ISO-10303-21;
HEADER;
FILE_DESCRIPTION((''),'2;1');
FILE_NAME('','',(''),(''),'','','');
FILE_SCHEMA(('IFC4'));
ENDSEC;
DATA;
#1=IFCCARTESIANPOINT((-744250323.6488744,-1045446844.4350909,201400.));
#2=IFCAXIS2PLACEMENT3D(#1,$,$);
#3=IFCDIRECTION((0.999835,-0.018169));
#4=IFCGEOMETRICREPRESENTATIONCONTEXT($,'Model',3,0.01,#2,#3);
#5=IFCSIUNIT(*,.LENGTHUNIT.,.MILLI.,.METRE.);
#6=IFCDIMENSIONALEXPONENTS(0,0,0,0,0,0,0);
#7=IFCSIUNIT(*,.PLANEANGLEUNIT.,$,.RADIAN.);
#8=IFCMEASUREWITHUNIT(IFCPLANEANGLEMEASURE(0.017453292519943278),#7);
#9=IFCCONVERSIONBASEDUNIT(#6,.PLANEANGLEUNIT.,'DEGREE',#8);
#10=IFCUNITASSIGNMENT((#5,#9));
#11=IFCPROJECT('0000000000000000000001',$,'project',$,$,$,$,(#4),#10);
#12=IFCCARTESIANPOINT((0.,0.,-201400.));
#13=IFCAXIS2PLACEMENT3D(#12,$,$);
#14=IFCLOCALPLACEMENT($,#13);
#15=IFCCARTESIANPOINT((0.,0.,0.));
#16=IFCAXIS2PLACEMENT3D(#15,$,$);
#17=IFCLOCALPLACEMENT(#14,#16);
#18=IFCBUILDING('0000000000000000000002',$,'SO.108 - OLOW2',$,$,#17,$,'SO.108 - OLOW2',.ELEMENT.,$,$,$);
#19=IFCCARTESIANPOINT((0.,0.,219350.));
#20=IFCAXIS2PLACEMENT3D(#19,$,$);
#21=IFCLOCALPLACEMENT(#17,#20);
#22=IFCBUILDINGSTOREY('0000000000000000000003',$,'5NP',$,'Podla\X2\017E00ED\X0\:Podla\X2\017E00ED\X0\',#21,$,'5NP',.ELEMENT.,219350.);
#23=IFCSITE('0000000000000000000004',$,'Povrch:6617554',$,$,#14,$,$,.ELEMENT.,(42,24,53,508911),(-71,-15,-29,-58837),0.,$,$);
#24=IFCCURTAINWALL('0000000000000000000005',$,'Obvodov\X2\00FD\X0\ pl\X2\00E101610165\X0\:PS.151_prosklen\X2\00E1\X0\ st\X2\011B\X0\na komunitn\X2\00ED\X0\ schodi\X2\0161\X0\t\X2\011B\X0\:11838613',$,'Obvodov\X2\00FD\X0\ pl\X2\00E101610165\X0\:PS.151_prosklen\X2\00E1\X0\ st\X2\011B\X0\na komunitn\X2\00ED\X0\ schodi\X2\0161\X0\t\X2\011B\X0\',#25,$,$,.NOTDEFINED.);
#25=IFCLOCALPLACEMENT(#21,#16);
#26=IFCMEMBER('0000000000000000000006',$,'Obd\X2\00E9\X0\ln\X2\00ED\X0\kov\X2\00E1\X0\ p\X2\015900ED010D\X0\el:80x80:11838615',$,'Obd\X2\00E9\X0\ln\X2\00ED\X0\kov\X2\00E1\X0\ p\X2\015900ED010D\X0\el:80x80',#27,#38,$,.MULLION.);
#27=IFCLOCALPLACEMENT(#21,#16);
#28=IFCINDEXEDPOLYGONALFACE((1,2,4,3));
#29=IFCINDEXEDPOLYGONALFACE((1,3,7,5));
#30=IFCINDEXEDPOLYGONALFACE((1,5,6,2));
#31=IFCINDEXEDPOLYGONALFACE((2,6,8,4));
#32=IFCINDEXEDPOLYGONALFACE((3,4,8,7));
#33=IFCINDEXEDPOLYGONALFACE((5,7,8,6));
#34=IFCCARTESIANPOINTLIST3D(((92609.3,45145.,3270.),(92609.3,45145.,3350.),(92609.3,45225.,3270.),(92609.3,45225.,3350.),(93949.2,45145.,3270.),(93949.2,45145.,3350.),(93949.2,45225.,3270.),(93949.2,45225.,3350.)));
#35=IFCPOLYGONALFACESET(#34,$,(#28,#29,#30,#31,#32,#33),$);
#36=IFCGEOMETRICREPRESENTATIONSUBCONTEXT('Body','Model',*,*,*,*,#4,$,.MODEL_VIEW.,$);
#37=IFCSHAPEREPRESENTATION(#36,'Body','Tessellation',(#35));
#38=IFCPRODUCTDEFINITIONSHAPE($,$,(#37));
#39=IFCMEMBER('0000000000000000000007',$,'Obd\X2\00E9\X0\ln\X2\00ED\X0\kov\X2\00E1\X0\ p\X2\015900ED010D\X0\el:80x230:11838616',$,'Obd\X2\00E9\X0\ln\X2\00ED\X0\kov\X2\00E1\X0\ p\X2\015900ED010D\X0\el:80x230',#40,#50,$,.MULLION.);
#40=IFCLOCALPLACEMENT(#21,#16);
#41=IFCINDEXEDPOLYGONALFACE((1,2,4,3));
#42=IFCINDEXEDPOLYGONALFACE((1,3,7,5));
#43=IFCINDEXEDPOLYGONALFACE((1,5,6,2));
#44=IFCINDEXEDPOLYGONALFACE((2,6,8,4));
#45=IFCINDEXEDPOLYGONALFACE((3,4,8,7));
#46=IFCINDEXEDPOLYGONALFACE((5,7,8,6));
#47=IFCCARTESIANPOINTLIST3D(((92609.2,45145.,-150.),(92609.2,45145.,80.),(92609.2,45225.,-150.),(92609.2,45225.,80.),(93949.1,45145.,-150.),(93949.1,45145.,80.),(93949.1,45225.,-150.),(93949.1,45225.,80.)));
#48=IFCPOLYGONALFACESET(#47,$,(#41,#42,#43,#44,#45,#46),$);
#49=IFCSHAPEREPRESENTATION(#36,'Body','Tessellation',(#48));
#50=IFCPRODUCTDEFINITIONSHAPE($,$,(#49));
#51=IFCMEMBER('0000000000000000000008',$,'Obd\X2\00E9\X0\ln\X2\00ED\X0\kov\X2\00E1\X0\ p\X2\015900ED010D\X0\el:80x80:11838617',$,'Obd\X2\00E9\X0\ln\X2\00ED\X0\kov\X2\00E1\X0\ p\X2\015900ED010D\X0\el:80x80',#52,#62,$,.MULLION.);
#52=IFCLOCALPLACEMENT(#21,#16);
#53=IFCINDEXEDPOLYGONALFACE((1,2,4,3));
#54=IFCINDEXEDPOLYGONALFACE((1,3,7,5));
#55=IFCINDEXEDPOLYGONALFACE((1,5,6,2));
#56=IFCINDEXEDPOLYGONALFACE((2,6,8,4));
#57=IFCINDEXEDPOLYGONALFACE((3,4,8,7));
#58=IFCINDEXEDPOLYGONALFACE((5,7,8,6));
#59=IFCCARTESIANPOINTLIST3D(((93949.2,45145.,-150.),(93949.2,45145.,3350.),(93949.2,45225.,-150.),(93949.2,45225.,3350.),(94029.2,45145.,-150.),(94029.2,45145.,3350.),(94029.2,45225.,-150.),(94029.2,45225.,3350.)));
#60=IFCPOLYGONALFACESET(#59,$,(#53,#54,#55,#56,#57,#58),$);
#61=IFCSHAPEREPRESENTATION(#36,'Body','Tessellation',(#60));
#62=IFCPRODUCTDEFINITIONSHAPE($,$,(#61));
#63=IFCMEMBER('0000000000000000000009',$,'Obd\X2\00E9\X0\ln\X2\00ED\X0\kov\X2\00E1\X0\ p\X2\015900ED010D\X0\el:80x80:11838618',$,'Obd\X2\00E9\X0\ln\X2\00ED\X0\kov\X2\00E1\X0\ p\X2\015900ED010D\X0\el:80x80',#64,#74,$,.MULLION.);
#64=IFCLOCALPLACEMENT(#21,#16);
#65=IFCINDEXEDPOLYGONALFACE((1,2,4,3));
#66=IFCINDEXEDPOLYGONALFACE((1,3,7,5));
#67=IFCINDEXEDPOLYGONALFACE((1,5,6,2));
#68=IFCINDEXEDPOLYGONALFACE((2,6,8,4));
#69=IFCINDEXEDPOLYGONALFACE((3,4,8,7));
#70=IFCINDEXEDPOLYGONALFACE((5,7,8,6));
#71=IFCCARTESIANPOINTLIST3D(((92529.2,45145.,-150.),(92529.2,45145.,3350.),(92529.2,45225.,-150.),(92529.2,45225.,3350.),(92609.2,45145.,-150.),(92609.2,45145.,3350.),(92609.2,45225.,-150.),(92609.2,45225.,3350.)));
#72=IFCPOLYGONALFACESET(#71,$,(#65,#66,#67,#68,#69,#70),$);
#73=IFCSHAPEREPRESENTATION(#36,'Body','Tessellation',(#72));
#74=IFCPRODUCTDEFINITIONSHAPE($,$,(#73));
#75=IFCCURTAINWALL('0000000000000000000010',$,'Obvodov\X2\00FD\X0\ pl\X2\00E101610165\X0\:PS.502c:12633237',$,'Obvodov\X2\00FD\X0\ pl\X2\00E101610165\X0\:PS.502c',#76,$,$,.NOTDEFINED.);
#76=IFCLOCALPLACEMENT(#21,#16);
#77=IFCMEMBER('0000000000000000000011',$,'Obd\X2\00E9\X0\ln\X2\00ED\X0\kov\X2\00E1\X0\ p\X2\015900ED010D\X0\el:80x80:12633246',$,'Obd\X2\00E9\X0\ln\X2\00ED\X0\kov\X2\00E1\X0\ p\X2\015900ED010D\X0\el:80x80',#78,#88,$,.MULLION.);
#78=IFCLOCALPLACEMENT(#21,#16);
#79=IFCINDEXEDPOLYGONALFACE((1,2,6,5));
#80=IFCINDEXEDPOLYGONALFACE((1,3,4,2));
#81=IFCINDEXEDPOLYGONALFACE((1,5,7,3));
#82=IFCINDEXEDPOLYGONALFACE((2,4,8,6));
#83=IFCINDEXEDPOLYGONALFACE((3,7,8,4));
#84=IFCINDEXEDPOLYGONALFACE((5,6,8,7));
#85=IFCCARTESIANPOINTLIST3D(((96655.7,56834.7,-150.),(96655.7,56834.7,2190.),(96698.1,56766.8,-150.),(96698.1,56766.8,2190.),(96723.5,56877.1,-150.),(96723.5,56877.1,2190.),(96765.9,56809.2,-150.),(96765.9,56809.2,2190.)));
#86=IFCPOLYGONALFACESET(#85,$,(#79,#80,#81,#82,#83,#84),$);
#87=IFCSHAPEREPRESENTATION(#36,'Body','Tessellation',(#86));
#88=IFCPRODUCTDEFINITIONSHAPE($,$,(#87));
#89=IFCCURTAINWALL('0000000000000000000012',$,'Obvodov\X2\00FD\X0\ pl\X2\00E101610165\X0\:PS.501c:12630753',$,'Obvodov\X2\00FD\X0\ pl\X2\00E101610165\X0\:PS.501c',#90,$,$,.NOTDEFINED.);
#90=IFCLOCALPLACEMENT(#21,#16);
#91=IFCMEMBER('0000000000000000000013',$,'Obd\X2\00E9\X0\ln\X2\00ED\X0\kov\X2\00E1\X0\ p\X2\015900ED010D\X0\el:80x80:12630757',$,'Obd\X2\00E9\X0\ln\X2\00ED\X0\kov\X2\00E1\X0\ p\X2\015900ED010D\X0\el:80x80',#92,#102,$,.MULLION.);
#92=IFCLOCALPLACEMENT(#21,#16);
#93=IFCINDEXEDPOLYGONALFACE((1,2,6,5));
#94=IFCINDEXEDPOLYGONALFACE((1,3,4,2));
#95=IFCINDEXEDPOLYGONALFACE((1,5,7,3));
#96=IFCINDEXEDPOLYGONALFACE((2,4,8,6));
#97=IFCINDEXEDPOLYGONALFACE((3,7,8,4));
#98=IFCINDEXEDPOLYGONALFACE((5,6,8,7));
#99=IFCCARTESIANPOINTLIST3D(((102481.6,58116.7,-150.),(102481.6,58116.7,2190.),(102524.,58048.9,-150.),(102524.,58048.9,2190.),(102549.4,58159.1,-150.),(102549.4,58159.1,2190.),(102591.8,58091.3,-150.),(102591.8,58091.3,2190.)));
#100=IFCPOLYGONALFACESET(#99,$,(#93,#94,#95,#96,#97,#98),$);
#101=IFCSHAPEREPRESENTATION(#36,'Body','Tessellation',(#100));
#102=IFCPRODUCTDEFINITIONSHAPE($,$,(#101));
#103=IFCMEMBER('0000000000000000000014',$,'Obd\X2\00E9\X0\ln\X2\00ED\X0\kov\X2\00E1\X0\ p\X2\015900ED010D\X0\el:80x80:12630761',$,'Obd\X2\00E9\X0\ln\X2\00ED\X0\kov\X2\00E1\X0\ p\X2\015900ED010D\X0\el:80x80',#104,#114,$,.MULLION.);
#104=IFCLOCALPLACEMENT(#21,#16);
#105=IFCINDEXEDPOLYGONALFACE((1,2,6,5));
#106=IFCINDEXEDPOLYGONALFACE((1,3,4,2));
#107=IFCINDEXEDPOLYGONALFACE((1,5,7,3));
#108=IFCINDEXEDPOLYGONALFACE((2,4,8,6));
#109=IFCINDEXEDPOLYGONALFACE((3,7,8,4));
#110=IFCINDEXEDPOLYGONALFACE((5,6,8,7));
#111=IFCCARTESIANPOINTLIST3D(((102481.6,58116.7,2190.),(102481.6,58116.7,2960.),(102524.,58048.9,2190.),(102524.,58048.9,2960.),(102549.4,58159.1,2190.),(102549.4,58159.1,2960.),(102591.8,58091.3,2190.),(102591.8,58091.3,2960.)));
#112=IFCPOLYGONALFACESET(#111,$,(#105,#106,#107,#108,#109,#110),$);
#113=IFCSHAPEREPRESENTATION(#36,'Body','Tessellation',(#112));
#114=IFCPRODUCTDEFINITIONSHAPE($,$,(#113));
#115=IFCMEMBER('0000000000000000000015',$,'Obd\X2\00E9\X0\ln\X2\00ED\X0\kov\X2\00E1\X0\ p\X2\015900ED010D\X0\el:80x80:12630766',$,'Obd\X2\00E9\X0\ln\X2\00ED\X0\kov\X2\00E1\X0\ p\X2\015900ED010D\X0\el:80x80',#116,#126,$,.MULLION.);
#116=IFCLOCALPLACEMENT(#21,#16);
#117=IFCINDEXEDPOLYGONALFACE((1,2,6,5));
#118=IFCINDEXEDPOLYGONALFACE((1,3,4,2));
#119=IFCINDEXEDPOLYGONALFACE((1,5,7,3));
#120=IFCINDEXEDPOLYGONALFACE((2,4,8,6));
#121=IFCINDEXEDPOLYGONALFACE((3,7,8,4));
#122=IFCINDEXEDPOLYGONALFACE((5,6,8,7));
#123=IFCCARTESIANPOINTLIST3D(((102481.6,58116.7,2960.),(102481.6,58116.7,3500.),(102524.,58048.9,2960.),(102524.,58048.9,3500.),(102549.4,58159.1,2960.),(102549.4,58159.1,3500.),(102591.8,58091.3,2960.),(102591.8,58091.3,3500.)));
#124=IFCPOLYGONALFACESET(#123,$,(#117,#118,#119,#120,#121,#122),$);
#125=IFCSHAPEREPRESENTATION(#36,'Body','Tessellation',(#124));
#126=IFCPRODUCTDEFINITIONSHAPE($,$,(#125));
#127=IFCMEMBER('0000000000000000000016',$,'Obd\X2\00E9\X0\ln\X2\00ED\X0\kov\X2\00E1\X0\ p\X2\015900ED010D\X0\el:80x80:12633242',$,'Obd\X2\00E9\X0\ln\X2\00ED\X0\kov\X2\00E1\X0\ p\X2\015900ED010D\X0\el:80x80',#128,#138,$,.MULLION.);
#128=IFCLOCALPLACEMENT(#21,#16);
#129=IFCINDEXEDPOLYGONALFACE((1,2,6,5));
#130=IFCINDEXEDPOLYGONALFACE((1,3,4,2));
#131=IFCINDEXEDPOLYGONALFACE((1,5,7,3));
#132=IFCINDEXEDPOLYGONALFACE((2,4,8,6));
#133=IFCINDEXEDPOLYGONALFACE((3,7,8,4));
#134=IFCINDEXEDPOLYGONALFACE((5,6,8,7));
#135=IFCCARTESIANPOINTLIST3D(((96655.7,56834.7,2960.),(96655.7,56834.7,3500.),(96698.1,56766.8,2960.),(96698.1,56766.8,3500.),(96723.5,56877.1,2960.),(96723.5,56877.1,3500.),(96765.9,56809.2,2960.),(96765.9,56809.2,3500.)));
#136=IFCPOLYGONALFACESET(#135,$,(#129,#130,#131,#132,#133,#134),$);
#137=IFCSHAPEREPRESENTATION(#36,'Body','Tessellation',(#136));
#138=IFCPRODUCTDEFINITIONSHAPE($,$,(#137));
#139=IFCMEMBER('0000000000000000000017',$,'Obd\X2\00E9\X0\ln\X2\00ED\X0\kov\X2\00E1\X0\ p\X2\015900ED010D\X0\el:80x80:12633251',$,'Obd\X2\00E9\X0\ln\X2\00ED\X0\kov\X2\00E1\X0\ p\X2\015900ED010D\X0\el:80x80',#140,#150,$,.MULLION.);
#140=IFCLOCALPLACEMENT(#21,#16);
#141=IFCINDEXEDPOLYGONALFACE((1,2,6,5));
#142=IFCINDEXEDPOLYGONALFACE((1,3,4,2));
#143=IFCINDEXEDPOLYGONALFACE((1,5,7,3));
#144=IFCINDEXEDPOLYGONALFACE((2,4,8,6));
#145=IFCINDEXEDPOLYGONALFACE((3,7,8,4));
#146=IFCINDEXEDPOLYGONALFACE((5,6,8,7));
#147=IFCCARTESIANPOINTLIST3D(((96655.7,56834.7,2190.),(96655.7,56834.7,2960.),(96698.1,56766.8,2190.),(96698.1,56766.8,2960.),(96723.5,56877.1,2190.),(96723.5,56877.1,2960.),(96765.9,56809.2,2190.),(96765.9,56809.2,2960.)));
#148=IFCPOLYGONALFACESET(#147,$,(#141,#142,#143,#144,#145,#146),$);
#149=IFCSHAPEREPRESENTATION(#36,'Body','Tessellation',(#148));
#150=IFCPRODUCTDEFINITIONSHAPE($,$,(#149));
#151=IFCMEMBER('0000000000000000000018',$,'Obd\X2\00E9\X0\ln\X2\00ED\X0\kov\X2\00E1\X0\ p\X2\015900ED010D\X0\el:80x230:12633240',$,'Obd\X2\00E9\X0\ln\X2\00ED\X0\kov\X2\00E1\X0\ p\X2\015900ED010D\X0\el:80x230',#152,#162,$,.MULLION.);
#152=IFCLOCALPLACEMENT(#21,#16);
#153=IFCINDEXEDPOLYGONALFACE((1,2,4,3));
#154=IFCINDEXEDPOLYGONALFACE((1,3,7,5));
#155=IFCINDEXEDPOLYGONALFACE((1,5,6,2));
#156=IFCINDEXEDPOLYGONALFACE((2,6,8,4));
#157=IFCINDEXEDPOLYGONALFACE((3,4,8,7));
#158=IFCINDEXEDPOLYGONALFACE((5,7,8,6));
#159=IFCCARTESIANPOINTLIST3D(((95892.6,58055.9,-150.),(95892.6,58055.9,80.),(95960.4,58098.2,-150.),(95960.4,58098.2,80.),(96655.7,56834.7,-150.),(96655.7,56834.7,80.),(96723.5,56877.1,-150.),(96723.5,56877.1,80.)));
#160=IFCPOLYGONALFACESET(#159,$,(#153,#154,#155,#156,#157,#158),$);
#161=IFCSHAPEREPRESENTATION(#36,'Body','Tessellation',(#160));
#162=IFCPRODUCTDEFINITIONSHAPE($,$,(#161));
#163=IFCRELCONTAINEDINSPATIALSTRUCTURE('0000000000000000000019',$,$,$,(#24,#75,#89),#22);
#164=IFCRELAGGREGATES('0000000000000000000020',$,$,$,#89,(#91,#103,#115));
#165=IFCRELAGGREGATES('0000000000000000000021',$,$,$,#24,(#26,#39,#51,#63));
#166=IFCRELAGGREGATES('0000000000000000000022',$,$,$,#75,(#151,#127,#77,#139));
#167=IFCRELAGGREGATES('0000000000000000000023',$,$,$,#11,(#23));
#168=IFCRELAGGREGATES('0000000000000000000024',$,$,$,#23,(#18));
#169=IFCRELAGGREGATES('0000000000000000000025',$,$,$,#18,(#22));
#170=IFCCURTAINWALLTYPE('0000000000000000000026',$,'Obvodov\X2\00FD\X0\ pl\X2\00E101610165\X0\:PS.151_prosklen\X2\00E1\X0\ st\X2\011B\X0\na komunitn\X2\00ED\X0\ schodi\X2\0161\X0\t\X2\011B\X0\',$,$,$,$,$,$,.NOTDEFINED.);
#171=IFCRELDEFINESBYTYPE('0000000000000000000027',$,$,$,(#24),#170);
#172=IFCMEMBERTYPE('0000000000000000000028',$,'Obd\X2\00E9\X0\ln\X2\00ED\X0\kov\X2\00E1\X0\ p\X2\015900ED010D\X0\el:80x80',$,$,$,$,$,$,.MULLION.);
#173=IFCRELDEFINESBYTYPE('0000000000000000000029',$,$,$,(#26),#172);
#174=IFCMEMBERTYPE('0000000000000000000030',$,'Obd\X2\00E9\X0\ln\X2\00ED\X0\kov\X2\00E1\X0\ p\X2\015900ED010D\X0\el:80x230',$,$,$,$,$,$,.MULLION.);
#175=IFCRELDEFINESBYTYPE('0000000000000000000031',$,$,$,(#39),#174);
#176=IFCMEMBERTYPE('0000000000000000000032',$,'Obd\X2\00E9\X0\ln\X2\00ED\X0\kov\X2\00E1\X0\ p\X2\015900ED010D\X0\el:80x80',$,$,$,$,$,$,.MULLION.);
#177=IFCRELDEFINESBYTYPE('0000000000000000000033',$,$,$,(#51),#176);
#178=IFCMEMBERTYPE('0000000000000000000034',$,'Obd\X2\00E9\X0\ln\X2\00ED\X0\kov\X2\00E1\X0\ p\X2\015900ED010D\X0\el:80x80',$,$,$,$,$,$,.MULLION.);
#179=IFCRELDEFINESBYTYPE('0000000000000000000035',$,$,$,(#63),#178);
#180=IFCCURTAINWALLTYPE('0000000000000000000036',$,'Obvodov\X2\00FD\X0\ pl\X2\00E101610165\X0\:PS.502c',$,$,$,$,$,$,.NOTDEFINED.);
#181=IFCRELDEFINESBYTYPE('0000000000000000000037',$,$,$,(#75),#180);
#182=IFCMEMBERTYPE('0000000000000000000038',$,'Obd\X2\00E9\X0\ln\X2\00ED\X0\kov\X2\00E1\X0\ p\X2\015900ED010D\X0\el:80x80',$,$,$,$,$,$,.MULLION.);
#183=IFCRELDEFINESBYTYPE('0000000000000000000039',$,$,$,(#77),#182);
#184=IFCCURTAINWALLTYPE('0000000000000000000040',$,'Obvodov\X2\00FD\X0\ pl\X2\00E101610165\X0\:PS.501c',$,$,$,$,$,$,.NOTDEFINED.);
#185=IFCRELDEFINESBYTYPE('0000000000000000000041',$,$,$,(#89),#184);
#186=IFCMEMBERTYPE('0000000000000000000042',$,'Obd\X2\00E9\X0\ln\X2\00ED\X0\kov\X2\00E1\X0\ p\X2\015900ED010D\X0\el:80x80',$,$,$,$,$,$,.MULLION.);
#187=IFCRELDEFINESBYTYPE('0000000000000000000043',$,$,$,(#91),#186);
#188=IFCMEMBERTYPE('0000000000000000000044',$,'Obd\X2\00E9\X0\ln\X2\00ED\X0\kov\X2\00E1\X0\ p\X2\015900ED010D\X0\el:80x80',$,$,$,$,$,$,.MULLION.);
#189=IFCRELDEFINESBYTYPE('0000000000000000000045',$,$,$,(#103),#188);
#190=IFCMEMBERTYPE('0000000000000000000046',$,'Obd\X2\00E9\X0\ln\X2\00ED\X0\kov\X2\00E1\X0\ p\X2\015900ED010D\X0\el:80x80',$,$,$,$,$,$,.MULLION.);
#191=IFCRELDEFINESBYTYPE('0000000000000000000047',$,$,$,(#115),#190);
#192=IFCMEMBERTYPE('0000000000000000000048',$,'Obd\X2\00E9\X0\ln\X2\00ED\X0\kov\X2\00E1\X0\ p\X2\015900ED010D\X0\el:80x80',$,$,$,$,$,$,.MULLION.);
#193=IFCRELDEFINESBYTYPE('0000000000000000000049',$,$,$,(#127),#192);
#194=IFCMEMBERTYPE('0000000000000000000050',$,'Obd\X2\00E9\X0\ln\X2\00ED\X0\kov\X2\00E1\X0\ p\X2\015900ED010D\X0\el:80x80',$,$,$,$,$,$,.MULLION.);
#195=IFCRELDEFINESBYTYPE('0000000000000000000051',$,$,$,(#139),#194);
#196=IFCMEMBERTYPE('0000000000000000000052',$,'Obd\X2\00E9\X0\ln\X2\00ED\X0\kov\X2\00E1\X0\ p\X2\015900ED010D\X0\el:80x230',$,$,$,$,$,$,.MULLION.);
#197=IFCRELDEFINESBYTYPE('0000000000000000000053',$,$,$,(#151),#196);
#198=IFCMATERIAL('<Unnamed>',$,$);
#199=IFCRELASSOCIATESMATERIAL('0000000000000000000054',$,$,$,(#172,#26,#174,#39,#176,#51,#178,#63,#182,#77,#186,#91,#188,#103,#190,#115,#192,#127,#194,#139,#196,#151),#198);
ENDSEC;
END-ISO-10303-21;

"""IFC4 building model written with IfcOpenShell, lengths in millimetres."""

from ifc_helpers import new_model, entity, si_unit, converted_unit, direction, frame, origin, place, context, subcontext, project, spatial, indexed_curve, outline, extrude, source, transform, mapped, material, type_object, type_shapes, element, aggregate, save


model = new_model("IFC4")

# Units and contexts
model_context = context("Model", 3, precision=0.01, world=frame((-744250323.6488744, -1045446844.4350909, 201400.0)), true_north=direction((0.999835, -0.018169)))
body_context = subcontext(model_context, "Body", "Model", "MODEL_VIEW")
ifc_project = project(units=[si_unit("LENGTHUNIT", "METRE", prefix="MILLI"), converted_unit("PLANEANGLEUNIT", "DEGREE", entity("IfcPlaneAngleMeasure", 0.017453292519943278), si_unit("PLANEANGLEUNIT", "RADIAN"), dimensions=[0, 0, 0, 0, 0, 0, 0])], contexts=[model_context])

# Site, building, storey
site_placement = place(None, frame((0.0, 0.0, -201400.0)))
site = spatial("IfcSite", under=ifc_project, at=site_placement, Name="Povrch:6617554", CompositionType="ELEMENT", RefLatitude=(42, 24, 53, 508911), RefLongitude=(-71, -15, -29, -58837), RefElevation=0.0)
building_placement = place(site_placement, origin())
building = spatial("IfcBuilding", under=site, at=building_placement, Name="SO.108 - OLOW2", LongName="SO.108 - OLOW2", CompositionType="ELEMENT")
storey_placement = place(building_placement, frame((0.0, 0.0, 219350.0)))
storey = spatial("IfcBuildingStorey", under=building, at=storey_placement, Name="5NP", ObjectType="Podlaží:Podlaží", LongName="5NP", CompositionType="ELEMENT", Elevation=219350.0)

# Curtain wall, members
curtain_wall_type_1 = type_object("IfcCurtainWallType", Name="Obvodový plášť:PS.151_prosklená stěna komunitní schodiště", PredefinedType="NOTDEFINED")
curtain_wall_1_placement = place(storey_placement, frame((0.0, 0.0, -219350.0)))
curtain_wall_1 = element("IfcCurtainWall", 1, at=curtain_wall_1_placement, inside=storey, type_object=curtain_wall_type_1, Name="Obvodový plášť:PS.151_prosklená stěna komunitní schodiště:11838613", ObjectType="Obvodový plášť:PS.151_prosklená stěna komunitní schodiště", PredefinedType="NOTDEFINED")
ifc_material_1 = material(Name="<Unnamed>")
member_type_1 = type_object("IfcMemberType", Name="Obdélníková příčel:80x80", PredefinedType="MULLION", material=ifc_material_1)
shared_shape_1 = source(origin(), body_context, "Body", "SweptSolid", [
    extrude(outline(indexed_curve([(-40.0, -40.0), (40.0, -40.0), (40.0, 40.0), (-40.0, 40.0), (-40.0, -40.0)], self_intersect=False)), frame((-40.0, 0.0, -1339.9), z_axis=(0.0, 0.0, 1.0), x_axis=(-1.0, 0.0, 0.0)), (0.0, 0.0, 1.0), 1339.9),
])
type_shapes(member_type_1, [shared_shape_1])
member_1_placement = place(curtain_wall_1_placement, frame((93949.2, 45185.0, 222700.0), z_axis=(1.0, 0.0, 0.0), x_axis=(0.0, 0.0, 1.0)))
member_1 = element("IfcMember", 2, at=member_1_placement, type_object=member_type_1, material=ifc_material_1, Name="Obdélníková příčel:80x80:11838615", ObjectType="Obdélníková příčel:80x80", PredefinedType="MULLION", context=body_context, shape_type="MappedRepresentation", body=[
    mapped(shared_shape_1, transform((0.0, 0.0, 0.0), scale=1.0)),
])
member_type_2 = type_object("IfcMemberType", Name="Obdélníková příčel:80x230", PredefinedType="MULLION", material=ifc_material_1)
shared_shape_2 = source(origin(), body_context, "Body", "SweptSolid", [
    extrude(outline(indexed_curve([(-115.0, -40.0), (115.0, -40.0), (115.0, 40.0), (-115.0, 40.0), (-115.0, -40.0)], self_intersect=False)), frame((-115.0, 0.0, -1339.9), z_axis=(0.0, 0.0, 1.0), x_axis=(-1.0, 0.0, 0.0)), (0.0, 0.0, 1.0), 1339.9),
])
type_shapes(member_type_2, [shared_shape_2])
member_2_placement = place(curtain_wall_1_placement, frame((92609.2, 45185.0, 219200.0), z_axis=(-1.0, 0.0, 0.0), x_axis=(0.0, 0.0, -1.0)))
member_2 = element("IfcMember", 3, at=member_2_placement, type_object=member_type_2, material=ifc_material_1, Name="Obdélníková příčel:80x230:11838616", ObjectType="Obdélníková příčel:80x230", PredefinedType="MULLION", context=body_context, shape_type="MappedRepresentation", body=[
    mapped(shared_shape_2, transform((0.0, 0.0, 0.0), scale=1.0)),
])
member_type_3 = type_object("IfcMemberType", Name="Obdélníková příčel:80x80", PredefinedType="MULLION", material=ifc_material_1)
shared_shape_3 = source(origin(), body_context, "Body", "SweptSolid", [
    extrude(outline(indexed_curve([(-40.0, -40.0), (40.0, -40.0), (40.0, 40.0), (-40.0, 40.0), (-40.0, -40.0)], self_intersect=False)), frame((-40.0, 0.0, -3500.0), z_axis=(0.0, 0.0, 1.0), x_axis=(-1.0, 0.0, 0.0)), (0.0, 0.0, 1.0), 3500.0),
])
type_shapes(member_type_3, [shared_shape_3])
member_3_placement = place(curtain_wall_1_placement, frame((94029.2, 45185.0, 219200.0), z_axis=(0.0, 0.0, -1.0), x_axis=(1.0, 0.0, 0.0)))
member_3 = element("IfcMember", 4, at=member_3_placement, type_object=member_type_3, material=ifc_material_1, Name="Obdélníková příčel:80x80:11838617", ObjectType="Obdélníková příčel:80x80", PredefinedType="MULLION", context=body_context, shape_type="MappedRepresentation", body=[
    mapped(shared_shape_3, transform((0.0, 0.0, 0.0), scale=1.0)),
])
member_type_4 = type_object("IfcMemberType", Name="Obdélníková příčel:80x80", PredefinedType="MULLION", material=ifc_material_1)
shared_shape_4 = source(origin(), body_context, "Body", "SweptSolid", [
    extrude(outline(indexed_curve([(-40.0, -40.0), (40.0, -40.0), (40.0, 40.0), (-40.0, 40.0), (-40.0, -40.0)], self_intersect=False)), frame((-40.0, 0.0, -3500.0), z_axis=(0.0, 0.0, 1.0), x_axis=(-1.0, 0.0, 0.0)), (0.0, 0.0, 1.0), 3500.0),
])
type_shapes(member_type_4, [shared_shape_4])
member_4_placement = place(curtain_wall_1_placement, frame((92529.2, 45185.0, 222700.0), z_axis=(0.0, 0.0, 1.0), x_axis=(-1.0, 0.0, 0.0)))
member_4 = element("IfcMember", 5, at=member_4_placement, type_object=member_type_4, material=ifc_material_1, Name="Obdélníková příčel:80x80:11838618", ObjectType="Obdélníková příčel:80x80", PredefinedType="MULLION", context=body_context, shape_type="MappedRepresentation", body=[
    mapped(shared_shape_4, transform((0.0, 0.0, 0.0), scale=1.0)),
])

# Curtain wall, member
curtain_wall_type_2 = type_object("IfcCurtainWallType", Name="Obvodový plášť:PS.502c", PredefinedType="NOTDEFINED")
curtain_wall_2_placement = place(storey_placement, frame((0.0, 0.0, -219350.0)))
curtain_wall_2 = element("IfcCurtainWall", 6, at=curtain_wall_2_placement, inside=storey, type_object=curtain_wall_type_2, Name="Obvodový plášť:PS.502c:12633237", ObjectType="Obvodový plášť:PS.502c", PredefinedType="NOTDEFINED")
member_type_5 = type_object("IfcMemberType", Name="Obdélníková příčel:80x80", PredefinedType="MULLION", material=ifc_material_1)
shared_shape_5 = source(origin(), body_context, "Body", "SweptSolid", [
    extrude(outline(indexed_curve([(-40.0, -40.0), (40.0, -40.0), (40.0, 40.0), (-40.0, 40.0), (-40.0, -40.0)], self_intersect=False)), frame((-40.0, 0.0, -2340.0), z_axis=(0.0, 0.0, 1.0), x_axis=(-1.0, 0.0, 0.0)), (0.0, 0.0, 1.0), 2340.0),
])
type_shapes(member_type_5, [shared_shape_5])
member_5_placement = place(curtain_wall_2_placement, frame((96732.0, 56788.0, 221540.0), z_axis=(0.0, 0.0, 1.0), x_axis=(0.529919, -0.848048, 0.0)))
member_5 = element("IfcMember", 7, at=member_5_placement, type_object=member_type_5, material=ifc_material_1, Name="Obdélníková příčel:80x80:12633246", ObjectType="Obdélníková příčel:80x80", PredefinedType="MULLION", context=body_context, shape_type="MappedRepresentation", body=[
    mapped(shared_shape_5, transform((0.0, 0.0, 0.0), scale=1.0)),
])

# Curtain wall, members
curtain_wall_type_3 = type_object("IfcCurtainWallType", Name="Obvodový plášť:PS.501c", PredefinedType="NOTDEFINED")
curtain_wall_3_placement = place(storey_placement, frame((0.0, 0.0, -219350.0)))
curtain_wall_3 = element("IfcCurtainWall", 8, at=curtain_wall_3_placement, inside=storey, type_object=curtain_wall_type_3, Name="Obvodový plášť:PS.501c:12630753", ObjectType="Obvodový plášť:PS.501c", PredefinedType="NOTDEFINED")
member_type_6 = type_object("IfcMemberType", Name="Obdélníková příčel:80x80", PredefinedType="MULLION", material=ifc_material_1)
shared_shape_6 = source(origin(), body_context, "Body", "SweptSolid", [
    extrude(outline(indexed_curve([(-40.0, -40.0), (40.0, -40.0), (40.0, 40.0), (-40.0, 40.0), (-40.0, -40.0)], self_intersect=False)), frame((-40.0, 0.0, -2340.0), z_axis=(0.0, 0.0, 1.0), x_axis=(-1.0, 0.0, 0.0)), (0.0, 0.0, 1.0), 2340.0),
])
type_shapes(member_type_6, [shared_shape_6])
member_6_placement = place(curtain_wall_3_placement, frame((102557.9, 58070.1, 219200.0), z_axis=(0.0, 0.0, -1.0), x_axis=(0.529919, -0.848048, 0.0)))
member_6 = element("IfcMember", 9, at=member_6_placement, type_object=member_type_6, material=ifc_material_1, Name="Obdélníková příčel:80x80:12630757", ObjectType="Obdélníková příčel:80x80", PredefinedType="MULLION", context=body_context, shape_type="MappedRepresentation", body=[
    mapped(shared_shape_6, transform((0.0, 0.0, 0.0), scale=1.0)),
])
member_type_7 = type_object("IfcMemberType", Name="Obdélníková příčel:80x80", PredefinedType="MULLION", material=ifc_material_1)
shared_shape_7 = source(origin(), body_context, "Body", "SweptSolid", [
    extrude(outline(indexed_curve([(-40.0, -40.0), (40.0, -40.0), (40.0, 40.0), (-40.0, 40.0), (-40.0, -40.0)], self_intersect=False)), frame((-40.0, 0.0, -770.0), z_axis=(0.0, 0.0, 1.0), x_axis=(-1.0, 0.0, 0.0)), (0.0, 0.0, 1.0), 770.0),
])
type_shapes(member_type_7, [shared_shape_7])
member_7_placement = place(curtain_wall_3_placement, frame((102557.9, 58070.1, 221540.0), z_axis=(0.0, 0.0, -1.0), x_axis=(0.529919, -0.848048, 0.0)))
member_7 = element("IfcMember", 10, at=member_7_placement, type_object=member_type_7, material=ifc_material_1, Name="Obdélníková příčel:80x80:12630761", ObjectType="Obdélníková příčel:80x80", PredefinedType="MULLION", context=body_context, shape_type="MappedRepresentation", body=[
    mapped(shared_shape_7, transform((0.0, 0.0, 0.0), scale=1.0)),
])
member_type_8 = type_object("IfcMemberType", Name="Obdélníková příčel:80x80", PredefinedType="MULLION", material=ifc_material_1)
shared_shape_8 = source(origin(), body_context, "Body", "SweptSolid", [
    extrude(outline(indexed_curve([(-40.0, -40.0), (40.0, -40.0), (40.0, 40.0), (-40.0, 40.0), (-40.0, -40.0)], self_intersect=False)), frame((-40.0, 0.0, -540.0), z_axis=(0.0, 0.0, 1.0), x_axis=(-1.0, 0.0, 0.0)), (0.0, 0.0, 1.0), 540.0),
])
type_shapes(member_type_8, [shared_shape_8])
member_8_placement = place(curtain_wall_3_placement, frame((102557.9, 58070.1, 222310.0), z_axis=(0.0, 0.0, -1.0), x_axis=(0.529919, -0.848048, 0.0)))
member_8 = element("IfcMember", 11, at=member_8_placement, type_object=member_type_8, material=ifc_material_1, Name="Obdélníková příčel:80x80:12630766", ObjectType="Obdélníková příčel:80x80", PredefinedType="MULLION", context=body_context, shape_type="MappedRepresentation", body=[
    mapped(shared_shape_8, transform((0.0, 0.0, 0.0), scale=1.0)),
])
aggregate(curtain_wall_3, [member_6, member_7, member_8])

# Members
member_type_9 = type_object("IfcMemberType", Name="Obdélníková příčel:80x80", PredefinedType="MULLION", material=ifc_material_1)
shared_shape_9 = source(origin(), body_context, "Body", "SweptSolid", [
    extrude(outline(indexed_curve([(-40.0, -40.0), (40.0, -40.0), (40.0, 40.0), (-40.0, 40.0), (-40.0, -40.0)], self_intersect=False)), frame((-40.0, 0.0, -540.0), z_axis=(0.0, 0.0, 1.0), x_axis=(-1.0, 0.0, 0.0)), (0.0, 0.0, 1.0), 540.0),
])
type_shapes(member_type_9, [shared_shape_9])
member_9_placement = place(curtain_wall_2_placement, frame((96732.0, 56788.0, 222850.0), z_axis=(0.0, 0.0, 1.0), x_axis=(0.529919, -0.848048, 0.0)))
member_9 = element("IfcMember", 12, at=member_9_placement, type_object=member_type_9, material=ifc_material_1, Name="Obdélníková příčel:80x80:12633242", ObjectType="Obdélníková příčel:80x80", PredefinedType="MULLION", context=body_context, shape_type="MappedRepresentation", body=[
    mapped(shared_shape_9, transform((0.0, 0.0, 0.0), scale=1.0)),
])
member_type_10 = type_object("IfcMemberType", Name="Obdélníková příčel:80x80", PredefinedType="MULLION", material=ifc_material_1)
shared_shape_10 = source(origin(), body_context, "Body", "SweptSolid", [
    extrude(outline(indexed_curve([(-40.0, -40.0), (40.0, -40.0), (40.0, 40.0), (-40.0, 40.0), (-40.0, -40.0)], self_intersect=False)), frame((-40.0, 0.0, -770.0), z_axis=(0.0, 0.0, 1.0), x_axis=(-1.0, 0.0, 0.0)), (0.0, 0.0, 1.0), 770.0),
])
type_shapes(member_type_10, [shared_shape_10])
member_10_placement = place(curtain_wall_2_placement, frame((96732.0, 56788.0, 222310.0), z_axis=(0.0, 0.0, 1.0), x_axis=(0.529919, -0.848048, 0.0)))
member_10 = element("IfcMember", 13, at=member_10_placement, type_object=member_type_10, material=ifc_material_1, Name="Obdélníková příčel:80x80:12633251", ObjectType="Obdélníková příčel:80x80", PredefinedType="MULLION", context=body_context, shape_type="MappedRepresentation", body=[
    mapped(shared_shape_10, transform((0.0, 0.0, 0.0), scale=1.0)),
])
member_type_11 = type_object("IfcMemberType", Name="Obdélníková příčel:80x230", PredefinedType="MULLION", material=ifc_material_1)
shared_shape_11 = source(origin(), body_context, "Body", "SweptSolid", [
    extrude(outline(indexed_curve([(-115.0, -40.0), (115.0, -40.0), (115.0, 40.0), (-115.0, 40.0), (-115.0, -40.0)], self_intersect=False)), frame((-115.0, 0.0, -1440.0), z_axis=(0.0, 0.0, 1.0), x_axis=(-1.0, 0.0, 0.0)), (0.0, 0.0, 1.0), 1440.0),
])
type_shapes(member_type_11, [shared_shape_11])
member_11_placement = place(curtain_wall_2_placement, frame((96689.6, 56855.9, 219200.0), z_axis=(0.529919, -0.848048, 0.0), x_axis=(0.0, 0.0, -1.0)))
member_11 = element("IfcMember", 14, at=member_11_placement, type_object=member_type_11, material=ifc_material_1, Name="Obdélníková příčel:80x230:12633240", ObjectType="Obdélníková příčel:80x230", PredefinedType="MULLION", context=body_context, shape_type="MappedRepresentation", body=[
    mapped(shared_shape_11, transform((0.0, 0.0, 0.0), scale=1.0)),
])

aggregate(curtain_wall_1, [member_1, member_2, member_3, member_4])
aggregate(curtain_wall_2, [member_11, member_9, member_5, member_10])

save(model, "model.ifc")
